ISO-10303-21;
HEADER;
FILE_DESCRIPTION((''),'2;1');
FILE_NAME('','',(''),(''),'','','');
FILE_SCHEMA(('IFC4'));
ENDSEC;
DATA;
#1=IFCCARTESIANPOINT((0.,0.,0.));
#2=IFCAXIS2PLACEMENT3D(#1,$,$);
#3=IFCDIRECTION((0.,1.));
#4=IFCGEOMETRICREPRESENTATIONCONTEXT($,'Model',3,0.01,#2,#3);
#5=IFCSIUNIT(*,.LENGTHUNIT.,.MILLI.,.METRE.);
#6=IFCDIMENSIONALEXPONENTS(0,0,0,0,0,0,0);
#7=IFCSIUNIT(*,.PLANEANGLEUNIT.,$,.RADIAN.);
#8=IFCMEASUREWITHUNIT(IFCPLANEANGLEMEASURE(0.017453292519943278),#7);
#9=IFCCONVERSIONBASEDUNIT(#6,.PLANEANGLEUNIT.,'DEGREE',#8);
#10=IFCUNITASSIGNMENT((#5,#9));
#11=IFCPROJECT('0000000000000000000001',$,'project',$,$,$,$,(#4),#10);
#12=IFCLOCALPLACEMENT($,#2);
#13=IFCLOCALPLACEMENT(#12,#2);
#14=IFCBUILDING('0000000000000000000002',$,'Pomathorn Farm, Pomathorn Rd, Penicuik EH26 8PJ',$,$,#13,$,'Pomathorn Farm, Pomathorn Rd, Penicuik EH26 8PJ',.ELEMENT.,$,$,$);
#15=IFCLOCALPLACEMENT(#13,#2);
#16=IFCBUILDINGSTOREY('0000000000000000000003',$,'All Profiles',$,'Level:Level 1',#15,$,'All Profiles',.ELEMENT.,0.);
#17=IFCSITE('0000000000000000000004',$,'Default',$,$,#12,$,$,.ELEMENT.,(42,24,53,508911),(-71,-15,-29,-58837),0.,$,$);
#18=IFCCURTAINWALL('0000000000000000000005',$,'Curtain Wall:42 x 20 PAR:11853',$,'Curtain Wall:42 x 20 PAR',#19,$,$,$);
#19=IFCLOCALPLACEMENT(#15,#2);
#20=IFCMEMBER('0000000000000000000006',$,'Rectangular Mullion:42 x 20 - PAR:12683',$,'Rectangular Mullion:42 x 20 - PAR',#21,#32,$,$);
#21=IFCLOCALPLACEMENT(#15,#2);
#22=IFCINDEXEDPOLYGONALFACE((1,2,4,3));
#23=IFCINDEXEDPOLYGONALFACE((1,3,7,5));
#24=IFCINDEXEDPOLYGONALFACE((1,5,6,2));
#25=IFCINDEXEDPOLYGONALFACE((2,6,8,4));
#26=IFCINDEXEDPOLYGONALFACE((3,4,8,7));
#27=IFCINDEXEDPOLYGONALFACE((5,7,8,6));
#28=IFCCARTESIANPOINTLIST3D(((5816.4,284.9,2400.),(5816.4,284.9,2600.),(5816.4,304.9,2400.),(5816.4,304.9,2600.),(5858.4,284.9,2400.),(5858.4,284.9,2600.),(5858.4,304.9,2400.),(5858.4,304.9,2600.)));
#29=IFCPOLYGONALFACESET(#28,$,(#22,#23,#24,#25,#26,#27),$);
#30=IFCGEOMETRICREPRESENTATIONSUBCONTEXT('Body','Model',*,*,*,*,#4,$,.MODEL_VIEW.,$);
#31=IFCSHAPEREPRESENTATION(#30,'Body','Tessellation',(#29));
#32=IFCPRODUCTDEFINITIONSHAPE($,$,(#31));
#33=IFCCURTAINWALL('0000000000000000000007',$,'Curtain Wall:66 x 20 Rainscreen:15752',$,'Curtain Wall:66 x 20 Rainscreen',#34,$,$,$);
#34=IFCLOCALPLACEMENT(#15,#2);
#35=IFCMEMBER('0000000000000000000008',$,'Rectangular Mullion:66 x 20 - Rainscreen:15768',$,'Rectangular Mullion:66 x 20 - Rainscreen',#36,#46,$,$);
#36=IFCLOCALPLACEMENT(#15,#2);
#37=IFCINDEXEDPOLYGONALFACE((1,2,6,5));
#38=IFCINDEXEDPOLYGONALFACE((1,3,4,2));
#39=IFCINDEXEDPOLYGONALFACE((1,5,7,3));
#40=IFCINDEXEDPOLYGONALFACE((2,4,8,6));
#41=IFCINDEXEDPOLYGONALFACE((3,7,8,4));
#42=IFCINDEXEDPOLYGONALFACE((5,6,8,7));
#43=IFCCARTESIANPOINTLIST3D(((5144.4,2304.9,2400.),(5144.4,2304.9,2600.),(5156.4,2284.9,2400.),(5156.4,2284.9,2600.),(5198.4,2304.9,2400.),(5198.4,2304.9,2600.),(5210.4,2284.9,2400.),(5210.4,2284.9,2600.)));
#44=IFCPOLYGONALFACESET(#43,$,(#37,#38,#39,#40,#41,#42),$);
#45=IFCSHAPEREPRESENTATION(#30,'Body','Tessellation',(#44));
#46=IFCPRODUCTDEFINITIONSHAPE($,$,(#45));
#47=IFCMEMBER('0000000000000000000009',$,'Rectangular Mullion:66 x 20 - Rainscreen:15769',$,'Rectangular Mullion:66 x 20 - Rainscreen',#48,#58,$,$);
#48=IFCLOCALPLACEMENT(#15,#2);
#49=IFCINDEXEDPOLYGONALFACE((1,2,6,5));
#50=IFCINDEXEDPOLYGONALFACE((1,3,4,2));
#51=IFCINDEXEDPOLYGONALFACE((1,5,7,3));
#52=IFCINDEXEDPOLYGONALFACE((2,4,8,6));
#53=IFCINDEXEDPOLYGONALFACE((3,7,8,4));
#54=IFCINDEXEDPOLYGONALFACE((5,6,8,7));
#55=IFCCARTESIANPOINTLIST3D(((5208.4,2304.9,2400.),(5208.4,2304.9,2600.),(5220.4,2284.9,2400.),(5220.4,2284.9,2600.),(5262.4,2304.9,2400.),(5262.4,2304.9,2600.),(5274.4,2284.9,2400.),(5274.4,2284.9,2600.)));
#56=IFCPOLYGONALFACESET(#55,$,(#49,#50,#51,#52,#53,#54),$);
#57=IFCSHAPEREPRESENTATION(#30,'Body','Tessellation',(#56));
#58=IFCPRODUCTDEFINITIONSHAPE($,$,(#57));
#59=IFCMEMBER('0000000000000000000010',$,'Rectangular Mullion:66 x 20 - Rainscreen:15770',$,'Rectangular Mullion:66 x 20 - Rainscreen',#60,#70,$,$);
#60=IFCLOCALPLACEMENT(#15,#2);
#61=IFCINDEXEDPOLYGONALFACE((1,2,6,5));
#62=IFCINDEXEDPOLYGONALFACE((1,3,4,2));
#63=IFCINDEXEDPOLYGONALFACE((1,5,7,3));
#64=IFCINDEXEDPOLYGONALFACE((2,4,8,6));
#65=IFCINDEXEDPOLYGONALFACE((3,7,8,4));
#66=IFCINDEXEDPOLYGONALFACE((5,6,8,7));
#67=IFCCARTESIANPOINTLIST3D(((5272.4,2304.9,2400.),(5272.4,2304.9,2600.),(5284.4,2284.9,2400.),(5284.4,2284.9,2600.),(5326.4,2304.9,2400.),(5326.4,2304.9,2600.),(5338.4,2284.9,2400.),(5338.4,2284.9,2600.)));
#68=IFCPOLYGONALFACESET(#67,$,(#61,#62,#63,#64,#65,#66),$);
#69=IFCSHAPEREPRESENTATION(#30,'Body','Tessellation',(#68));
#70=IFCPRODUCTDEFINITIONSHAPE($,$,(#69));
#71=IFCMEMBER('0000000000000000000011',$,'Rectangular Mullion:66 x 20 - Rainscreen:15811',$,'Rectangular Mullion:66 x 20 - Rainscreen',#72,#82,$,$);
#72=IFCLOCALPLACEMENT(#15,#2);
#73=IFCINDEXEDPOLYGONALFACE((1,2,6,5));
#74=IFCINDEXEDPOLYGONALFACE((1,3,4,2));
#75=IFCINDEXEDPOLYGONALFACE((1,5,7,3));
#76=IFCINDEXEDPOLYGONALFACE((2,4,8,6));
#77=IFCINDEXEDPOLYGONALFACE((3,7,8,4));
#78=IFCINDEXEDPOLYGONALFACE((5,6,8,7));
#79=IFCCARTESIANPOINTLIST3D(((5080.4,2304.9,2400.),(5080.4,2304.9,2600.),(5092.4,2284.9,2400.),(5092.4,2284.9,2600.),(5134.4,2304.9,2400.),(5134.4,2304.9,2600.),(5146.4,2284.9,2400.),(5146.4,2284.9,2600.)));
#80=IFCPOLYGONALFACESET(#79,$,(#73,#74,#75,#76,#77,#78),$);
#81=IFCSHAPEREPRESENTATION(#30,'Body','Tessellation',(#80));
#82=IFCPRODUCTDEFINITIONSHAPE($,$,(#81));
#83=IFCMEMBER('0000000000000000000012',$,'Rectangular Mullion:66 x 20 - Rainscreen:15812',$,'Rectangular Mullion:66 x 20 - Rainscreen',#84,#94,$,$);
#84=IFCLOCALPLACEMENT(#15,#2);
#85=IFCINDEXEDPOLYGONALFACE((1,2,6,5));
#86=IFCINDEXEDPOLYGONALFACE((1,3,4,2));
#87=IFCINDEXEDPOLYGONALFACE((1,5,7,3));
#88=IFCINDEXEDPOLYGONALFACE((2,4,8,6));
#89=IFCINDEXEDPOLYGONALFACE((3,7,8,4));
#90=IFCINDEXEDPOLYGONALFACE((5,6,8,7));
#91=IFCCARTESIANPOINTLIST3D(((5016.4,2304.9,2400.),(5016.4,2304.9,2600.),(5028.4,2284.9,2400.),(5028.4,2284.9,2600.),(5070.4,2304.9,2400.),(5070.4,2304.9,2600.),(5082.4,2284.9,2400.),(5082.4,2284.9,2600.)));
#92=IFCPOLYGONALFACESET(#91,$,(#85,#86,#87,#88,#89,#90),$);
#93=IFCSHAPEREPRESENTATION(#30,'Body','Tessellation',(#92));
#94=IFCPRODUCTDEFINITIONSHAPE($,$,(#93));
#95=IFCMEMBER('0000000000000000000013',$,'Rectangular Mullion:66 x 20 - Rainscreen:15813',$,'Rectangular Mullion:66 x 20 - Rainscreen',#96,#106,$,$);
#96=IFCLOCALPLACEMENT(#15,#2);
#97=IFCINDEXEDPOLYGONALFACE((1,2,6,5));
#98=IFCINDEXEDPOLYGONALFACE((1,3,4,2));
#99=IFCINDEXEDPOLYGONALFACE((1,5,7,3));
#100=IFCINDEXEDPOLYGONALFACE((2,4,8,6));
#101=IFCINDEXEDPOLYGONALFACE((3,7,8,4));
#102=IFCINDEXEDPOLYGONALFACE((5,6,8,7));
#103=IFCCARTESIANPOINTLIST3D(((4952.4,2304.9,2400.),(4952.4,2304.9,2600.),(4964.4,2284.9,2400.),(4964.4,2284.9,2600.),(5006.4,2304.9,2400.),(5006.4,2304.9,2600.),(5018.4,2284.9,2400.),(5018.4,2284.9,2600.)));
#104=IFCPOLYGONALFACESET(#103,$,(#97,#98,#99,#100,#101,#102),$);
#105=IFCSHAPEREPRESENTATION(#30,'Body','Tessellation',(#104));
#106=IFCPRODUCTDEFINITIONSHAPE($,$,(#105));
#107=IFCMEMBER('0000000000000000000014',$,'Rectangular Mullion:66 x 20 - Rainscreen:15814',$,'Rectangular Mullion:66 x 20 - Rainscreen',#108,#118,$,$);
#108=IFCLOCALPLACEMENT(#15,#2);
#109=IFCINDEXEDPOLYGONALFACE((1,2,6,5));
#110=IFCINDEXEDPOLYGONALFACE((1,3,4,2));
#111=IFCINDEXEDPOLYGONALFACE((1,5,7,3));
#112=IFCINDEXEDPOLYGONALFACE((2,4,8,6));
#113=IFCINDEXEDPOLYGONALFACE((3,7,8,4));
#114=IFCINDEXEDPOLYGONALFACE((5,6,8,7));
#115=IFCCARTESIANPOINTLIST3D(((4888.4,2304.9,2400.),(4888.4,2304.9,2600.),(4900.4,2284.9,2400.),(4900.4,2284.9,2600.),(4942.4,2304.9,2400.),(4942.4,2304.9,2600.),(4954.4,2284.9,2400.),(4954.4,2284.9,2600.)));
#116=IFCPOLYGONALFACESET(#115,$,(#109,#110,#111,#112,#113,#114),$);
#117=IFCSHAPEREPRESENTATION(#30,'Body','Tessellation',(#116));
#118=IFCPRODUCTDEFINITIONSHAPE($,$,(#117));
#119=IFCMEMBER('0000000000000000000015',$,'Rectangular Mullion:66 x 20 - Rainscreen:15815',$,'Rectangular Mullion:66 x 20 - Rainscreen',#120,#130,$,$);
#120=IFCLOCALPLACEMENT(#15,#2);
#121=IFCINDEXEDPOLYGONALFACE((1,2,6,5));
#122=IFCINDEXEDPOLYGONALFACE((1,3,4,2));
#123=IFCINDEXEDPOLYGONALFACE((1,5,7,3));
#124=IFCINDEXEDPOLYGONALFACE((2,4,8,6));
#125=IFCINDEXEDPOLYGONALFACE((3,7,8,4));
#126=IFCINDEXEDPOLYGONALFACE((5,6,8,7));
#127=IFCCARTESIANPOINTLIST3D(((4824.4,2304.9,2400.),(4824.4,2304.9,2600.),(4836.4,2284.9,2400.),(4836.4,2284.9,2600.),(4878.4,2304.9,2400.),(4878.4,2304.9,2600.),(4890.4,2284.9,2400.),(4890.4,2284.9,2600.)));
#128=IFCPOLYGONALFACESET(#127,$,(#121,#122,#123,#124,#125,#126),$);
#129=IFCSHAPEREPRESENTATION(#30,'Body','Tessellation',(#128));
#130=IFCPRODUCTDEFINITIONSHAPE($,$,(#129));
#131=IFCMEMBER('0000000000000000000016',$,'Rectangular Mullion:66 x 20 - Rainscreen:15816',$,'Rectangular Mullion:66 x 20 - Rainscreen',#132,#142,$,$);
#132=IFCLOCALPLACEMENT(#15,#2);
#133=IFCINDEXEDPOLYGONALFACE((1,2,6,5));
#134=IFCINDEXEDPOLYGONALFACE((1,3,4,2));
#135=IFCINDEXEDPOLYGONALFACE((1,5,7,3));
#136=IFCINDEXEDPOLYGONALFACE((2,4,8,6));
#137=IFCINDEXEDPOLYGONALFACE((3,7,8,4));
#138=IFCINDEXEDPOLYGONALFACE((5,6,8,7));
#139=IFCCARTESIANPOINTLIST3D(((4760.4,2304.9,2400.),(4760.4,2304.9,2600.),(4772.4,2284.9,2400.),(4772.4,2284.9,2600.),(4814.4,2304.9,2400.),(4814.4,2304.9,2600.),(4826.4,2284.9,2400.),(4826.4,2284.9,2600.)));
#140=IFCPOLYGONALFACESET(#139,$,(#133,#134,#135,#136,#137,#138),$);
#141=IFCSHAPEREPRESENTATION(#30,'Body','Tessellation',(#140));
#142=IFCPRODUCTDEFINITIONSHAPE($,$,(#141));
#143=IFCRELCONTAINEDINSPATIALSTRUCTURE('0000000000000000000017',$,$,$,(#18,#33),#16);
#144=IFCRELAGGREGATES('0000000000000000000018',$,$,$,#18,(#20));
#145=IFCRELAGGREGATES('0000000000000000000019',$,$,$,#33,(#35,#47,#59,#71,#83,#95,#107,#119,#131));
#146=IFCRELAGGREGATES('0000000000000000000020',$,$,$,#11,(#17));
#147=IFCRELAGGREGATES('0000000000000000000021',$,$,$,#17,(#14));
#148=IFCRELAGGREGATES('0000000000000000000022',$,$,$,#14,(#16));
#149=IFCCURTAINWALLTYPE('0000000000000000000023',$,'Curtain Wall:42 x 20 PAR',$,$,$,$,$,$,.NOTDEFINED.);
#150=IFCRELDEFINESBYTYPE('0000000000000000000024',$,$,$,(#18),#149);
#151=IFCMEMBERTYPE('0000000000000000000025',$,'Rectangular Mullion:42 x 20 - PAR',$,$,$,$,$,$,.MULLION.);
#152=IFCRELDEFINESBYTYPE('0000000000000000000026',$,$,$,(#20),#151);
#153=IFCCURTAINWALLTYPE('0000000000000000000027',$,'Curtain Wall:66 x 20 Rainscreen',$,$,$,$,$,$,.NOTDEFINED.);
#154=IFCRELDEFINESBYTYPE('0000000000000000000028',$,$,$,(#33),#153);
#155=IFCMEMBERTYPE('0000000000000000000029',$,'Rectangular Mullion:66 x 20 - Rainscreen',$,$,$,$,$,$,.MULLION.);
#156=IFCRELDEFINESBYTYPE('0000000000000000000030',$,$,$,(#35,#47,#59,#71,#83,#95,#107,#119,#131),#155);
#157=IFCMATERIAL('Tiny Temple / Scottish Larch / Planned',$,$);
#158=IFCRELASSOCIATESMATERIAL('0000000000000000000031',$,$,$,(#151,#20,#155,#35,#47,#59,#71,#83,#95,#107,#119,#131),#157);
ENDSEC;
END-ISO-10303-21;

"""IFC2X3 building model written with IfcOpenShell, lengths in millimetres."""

from ifc_helpers import new_model, entity, si_unit, converted_unit, direction, frame, frame_2d, origin, place, context, subcontext, project, spatial, polyline, rectangle, outline, extrude, source, transform, mapped, material, type_object, type_shapes, element, aggregate, save


model = new_model("IFC2X3")

# Units and contexts
model_context = context("Model", 3, precision=0.01, world=origin(), true_north=direction((0.0, 1.0)))
body_context = subcontext(model_context, "Body", "Model", "MODEL_VIEW")
ifc_project = project(units=[si_unit("LENGTHUNIT", "METRE", prefix="MILLI"), converted_unit("PLANEANGLEUNIT", "DEGREE", entity("IfcPlaneAngleMeasure", 0.017453292519943278), si_unit("PLANEANGLEUNIT", "RADIAN"), dimensions=[0, 0, 0, 0, 0, 0, 0])], contexts=[model_context])

# Site, building, storey
site_placement = place(None, origin())
site = spatial("IfcSite", under=ifc_project, at=site_placement, Name="Default", CompositionType="ELEMENT", RefLatitude=(42, 24, 53, 508911), RefLongitude=(-71, -15, -29, -58837), RefElevation=0.0)
building_placement = place(site_placement, origin())
building = spatial("IfcBuilding", under=site, at=building_placement, Name="Pomathorn Farm, Pomathorn Rd, Penicuik EH26 8PJ", LongName="Pomathorn Farm, Pomathorn Rd, Penicuik EH26 8PJ", CompositionType="ELEMENT")
storey_placement = place(building_placement, origin())
storey = spatial("IfcBuildingStorey", under=building, at=storey_placement, Name="All Profiles", ObjectType="Level:Level 1", LongName="All Profiles", CompositionType="ELEMENT", Elevation=0.0)

# Curtain walls, members
ifc_material = material(Name="Tiny Temple / Scottish Larch / Planned")
curtain_wall_type_1 = type_object("IfcCurtainWallType", Name="Curtain Wall:42 x 20 PAR", PredefinedType="NOTDEFINED")
curtain_wall_1_placement = place(storey_placement, origin())
curtain_wall_1 = element("IfcCurtainWall", 1, at=curtain_wall_1_placement, inside=storey, type_object=curtain_wall_type_1, Name="Curtain Wall:42 x 20 PAR:11853", ObjectType="Curtain Wall:42 x 20 PAR")
member_type_1 = type_object("IfcMemberType", Name="Rectangular Mullion:42 x 20 - PAR", PredefinedType="MULLION", material=ifc_material)
shared_shape_1 = source(origin(), body_context, "Body", "SweptSolid", [
    extrude(rectangle(XDim=20.0, YDim=42.0, at=frame_2d((0.0, 0.0), x_axis=(1.0, 0.0))), frame((-21.0, -10.0, -200.0), z_axis=(0.0, 0.0, 1.0), x_axis=(0.0, 1.0, 0.0)), (0.0, 0.0, 1.0), 200.0),
])
type_shapes(member_type_1, [shared_shape_1])
member_1_placement = place(curtain_wall_1_placement, frame((5858.4, 284.9, 2400.0), z_axis=(0.0, 0.0, -1.0), x_axis=(1.0, 0.0, 0.0)))
member_1 = element("IfcMember", 2, at=member_1_placement, type_object=member_type_1, material=ifc_material, Name="Rectangular Mullion:42 x 20 - PAR:12683", ObjectType="Rectangular Mullion:42 x 20 - PAR", context=body_context, shape_type="MappedRepresentation", body=[
    mapped(shared_shape_1, transform((0.0, 0.0, 0.0), scale=1.0)),
])
aggregate(curtain_wall_1, [member_1])
curtain_wall_type_2 = type_object("IfcCurtainWallType", Name="Curtain Wall:66 x 20 Rainscreen", PredefinedType="NOTDEFINED")
curtain_wall_2_placement = place(storey_placement, origin())
curtain_wall_2 = element("IfcCurtainWall", 3, at=curtain_wall_2_placement, inside=storey, type_object=curtain_wall_type_2, Name="Curtain Wall:66 x 20 Rainscreen:15752", ObjectType="Curtain Wall:66 x 20 Rainscreen")
member_type_2 = type_object("IfcMemberType", Name="Rectangular Mullion:66 x 20 - Rainscreen", PredefinedType="MULLION", material=ifc_material)
shared_shape_2 = source(origin(), body_context, "Body", "SweptSolid", [
    extrude(outline(polyline([(2.2, -23.2), (25.6, -23.2), (-2.2, 23.2), (-25.6, 23.2), (2.2, -23.2)])), frame((-33.0, -10.0, -200.0), z_axis=(0.0, 0.0, 1.0), x_axis=(0.514496, 0.857493, 0.0)), (0.0, 0.0, 1.0), 200.0),
])
type_shapes(member_type_2, [shared_shape_2])
member_2_placement = place(curtain_wall_2_placement, frame((5210.4, 2284.9, 2400.0), z_axis=(0.0, 0.0, -1.0), x_axis=(1.0, 0.0, 0.0)))
member_2 = element("IfcMember", 4, at=member_2_placement, type_object=member_type_2, material=ifc_material, Name="Rectangular Mullion:66 x 20 - Rainscreen:15768", ObjectType="Rectangular Mullion:66 x 20 - Rainscreen", context=body_context, shape_type="MappedRepresentation", body=[
    mapped(shared_shape_2, transform((0.0, 0.0, 0.0), scale=1.0)),
])
member_3_placement = place(curtain_wall_2_placement, frame((5274.4, 2284.9, 2400.0), z_axis=(0.0, 0.0, -1.0), x_axis=(1.0, 0.0, 0.0)))
member_3 = element("IfcMember", 5, at=member_3_placement, type_object=member_type_2, material=ifc_material, Name="Rectangular Mullion:66 x 20 - Rainscreen:15769", ObjectType="Rectangular Mullion:66 x 20 - Rainscreen", context=body_context, shape_type="MappedRepresentation", body=[
    mapped(shared_shape_2, transform((0.0, 0.0, 0.0), scale=1.0)),
])
member_4_placement = place(curtain_wall_2_placement, frame((5338.4, 2284.9, 2400.0), z_axis=(0.0, 0.0, -1.0), x_axis=(1.0, 0.0, 0.0)))
member_4 = element("IfcMember", 6, at=member_4_placement, type_object=member_type_2, material=ifc_material, Name="Rectangular Mullion:66 x 20 - Rainscreen:15770", ObjectType="Rectangular Mullion:66 x 20 - Rainscreen", context=body_context, shape_type="MappedRepresentation", body=[
    mapped(shared_shape_2, transform((0.0, 0.0, 0.0), scale=1.0)),
])
member_5_placement = place(curtain_wall_2_placement, frame((5146.4, 2284.9, 2400.0), z_axis=(0.0, 0.0, -1.0), x_axis=(1.0, 0.0, 0.0)))
member_5 = element("IfcMember", 7, at=member_5_placement, type_object=member_type_2, material=ifc_material, Name="Rectangular Mullion:66 x 20 - Rainscreen:15811", ObjectType="Rectangular Mullion:66 x 20 - Rainscreen", context=body_context, shape_type="MappedRepresentation", body=[
    mapped(shared_shape_2, transform((0.0, 0.0, 0.0), scale=1.0)),
])
member_6_placement = place(curtain_wall_2_placement, frame((5082.4, 2284.9, 2400.0), z_axis=(0.0, 0.0, -1.0), x_axis=(1.0, 0.0, 0.0)))
member_6 = element("IfcMember", 8, at=member_6_placement, type_object=member_type_2, material=ifc_material, Name="Rectangular Mullion:66 x 20 - Rainscreen:15812", ObjectType="Rectangular Mullion:66 x 20 - Rainscreen", context=body_context, shape_type="MappedRepresentation", body=[
    mapped(shared_shape_2, transform((0.0, 0.0, 0.0), scale=1.0)),
])
member_7_placement = place(curtain_wall_2_placement, frame((5018.4, 2284.9, 2400.0), z_axis=(0.0, 0.0, -1.0), x_axis=(1.0, 0.0, 0.0)))
member_7 = element("IfcMember", 9, at=member_7_placement, type_object=member_type_2, material=ifc_material, Name="Rectangular Mullion:66 x 20 - Rainscreen:15813", ObjectType="Rectangular Mullion:66 x 20 - Rainscreen", context=body_context, shape_type="MappedRepresentation", body=[
    mapped(shared_shape_2, transform((0.0, 0.0, 0.0), scale=1.0)),
])
member_8_placement = place(curtain_wall_2_placement, frame((4954.4, 2284.9, 2400.0), z_axis=(0.0, 0.0, -1.0), x_axis=(1.0, 0.0, 0.0)))
member_8 = element("IfcMember", 10, at=member_8_placement, type_object=member_type_2, material=ifc_material, Name="Rectangular Mullion:66 x 20 - Rainscreen:15814", ObjectType="Rectangular Mullion:66 x 20 - Rainscreen", context=body_context, shape_type="MappedRepresentation", body=[
    mapped(shared_shape_2, transform((0.0, 0.0, 0.0), scale=1.0)),
])
member_9_placement = place(curtain_wall_2_placement, frame((4890.4, 2284.9, 2400.0), z_axis=(0.0, 0.0, -1.0), x_axis=(1.0, 0.0, 0.0)))
member_9 = element("IfcMember", 11, at=member_9_placement, type_object=member_type_2, material=ifc_material, Name="Rectangular Mullion:66 x 20 - Rainscreen:15815", ObjectType="Rectangular Mullion:66 x 20 - Rainscreen", context=body_context, shape_type="MappedRepresentation", body=[
    mapped(shared_shape_2, transform((0.0, 0.0, 0.0), scale=1.0)),
])
member_10_placement = place(curtain_wall_2_placement, frame((4826.4, 2284.9, 2400.0), z_axis=(0.0, 0.0, -1.0), x_axis=(1.0, 0.0, 0.0)))
member_10 = element("IfcMember", 12, at=member_10_placement, type_object=member_type_2, material=ifc_material, Name="Rectangular Mullion:66 x 20 - Rainscreen:15816", ObjectType="Rectangular Mullion:66 x 20 - Rainscreen", context=body_context, shape_type="MappedRepresentation", body=[
    mapped(shared_shape_2, transform((0.0, 0.0, 0.0), scale=1.0)),
])
aggregate(curtain_wall_2, [member_2, member_3, member_4, member_5, member_6, member_7, member_8, member_9, member_10])

save(model, "model.ifc")
